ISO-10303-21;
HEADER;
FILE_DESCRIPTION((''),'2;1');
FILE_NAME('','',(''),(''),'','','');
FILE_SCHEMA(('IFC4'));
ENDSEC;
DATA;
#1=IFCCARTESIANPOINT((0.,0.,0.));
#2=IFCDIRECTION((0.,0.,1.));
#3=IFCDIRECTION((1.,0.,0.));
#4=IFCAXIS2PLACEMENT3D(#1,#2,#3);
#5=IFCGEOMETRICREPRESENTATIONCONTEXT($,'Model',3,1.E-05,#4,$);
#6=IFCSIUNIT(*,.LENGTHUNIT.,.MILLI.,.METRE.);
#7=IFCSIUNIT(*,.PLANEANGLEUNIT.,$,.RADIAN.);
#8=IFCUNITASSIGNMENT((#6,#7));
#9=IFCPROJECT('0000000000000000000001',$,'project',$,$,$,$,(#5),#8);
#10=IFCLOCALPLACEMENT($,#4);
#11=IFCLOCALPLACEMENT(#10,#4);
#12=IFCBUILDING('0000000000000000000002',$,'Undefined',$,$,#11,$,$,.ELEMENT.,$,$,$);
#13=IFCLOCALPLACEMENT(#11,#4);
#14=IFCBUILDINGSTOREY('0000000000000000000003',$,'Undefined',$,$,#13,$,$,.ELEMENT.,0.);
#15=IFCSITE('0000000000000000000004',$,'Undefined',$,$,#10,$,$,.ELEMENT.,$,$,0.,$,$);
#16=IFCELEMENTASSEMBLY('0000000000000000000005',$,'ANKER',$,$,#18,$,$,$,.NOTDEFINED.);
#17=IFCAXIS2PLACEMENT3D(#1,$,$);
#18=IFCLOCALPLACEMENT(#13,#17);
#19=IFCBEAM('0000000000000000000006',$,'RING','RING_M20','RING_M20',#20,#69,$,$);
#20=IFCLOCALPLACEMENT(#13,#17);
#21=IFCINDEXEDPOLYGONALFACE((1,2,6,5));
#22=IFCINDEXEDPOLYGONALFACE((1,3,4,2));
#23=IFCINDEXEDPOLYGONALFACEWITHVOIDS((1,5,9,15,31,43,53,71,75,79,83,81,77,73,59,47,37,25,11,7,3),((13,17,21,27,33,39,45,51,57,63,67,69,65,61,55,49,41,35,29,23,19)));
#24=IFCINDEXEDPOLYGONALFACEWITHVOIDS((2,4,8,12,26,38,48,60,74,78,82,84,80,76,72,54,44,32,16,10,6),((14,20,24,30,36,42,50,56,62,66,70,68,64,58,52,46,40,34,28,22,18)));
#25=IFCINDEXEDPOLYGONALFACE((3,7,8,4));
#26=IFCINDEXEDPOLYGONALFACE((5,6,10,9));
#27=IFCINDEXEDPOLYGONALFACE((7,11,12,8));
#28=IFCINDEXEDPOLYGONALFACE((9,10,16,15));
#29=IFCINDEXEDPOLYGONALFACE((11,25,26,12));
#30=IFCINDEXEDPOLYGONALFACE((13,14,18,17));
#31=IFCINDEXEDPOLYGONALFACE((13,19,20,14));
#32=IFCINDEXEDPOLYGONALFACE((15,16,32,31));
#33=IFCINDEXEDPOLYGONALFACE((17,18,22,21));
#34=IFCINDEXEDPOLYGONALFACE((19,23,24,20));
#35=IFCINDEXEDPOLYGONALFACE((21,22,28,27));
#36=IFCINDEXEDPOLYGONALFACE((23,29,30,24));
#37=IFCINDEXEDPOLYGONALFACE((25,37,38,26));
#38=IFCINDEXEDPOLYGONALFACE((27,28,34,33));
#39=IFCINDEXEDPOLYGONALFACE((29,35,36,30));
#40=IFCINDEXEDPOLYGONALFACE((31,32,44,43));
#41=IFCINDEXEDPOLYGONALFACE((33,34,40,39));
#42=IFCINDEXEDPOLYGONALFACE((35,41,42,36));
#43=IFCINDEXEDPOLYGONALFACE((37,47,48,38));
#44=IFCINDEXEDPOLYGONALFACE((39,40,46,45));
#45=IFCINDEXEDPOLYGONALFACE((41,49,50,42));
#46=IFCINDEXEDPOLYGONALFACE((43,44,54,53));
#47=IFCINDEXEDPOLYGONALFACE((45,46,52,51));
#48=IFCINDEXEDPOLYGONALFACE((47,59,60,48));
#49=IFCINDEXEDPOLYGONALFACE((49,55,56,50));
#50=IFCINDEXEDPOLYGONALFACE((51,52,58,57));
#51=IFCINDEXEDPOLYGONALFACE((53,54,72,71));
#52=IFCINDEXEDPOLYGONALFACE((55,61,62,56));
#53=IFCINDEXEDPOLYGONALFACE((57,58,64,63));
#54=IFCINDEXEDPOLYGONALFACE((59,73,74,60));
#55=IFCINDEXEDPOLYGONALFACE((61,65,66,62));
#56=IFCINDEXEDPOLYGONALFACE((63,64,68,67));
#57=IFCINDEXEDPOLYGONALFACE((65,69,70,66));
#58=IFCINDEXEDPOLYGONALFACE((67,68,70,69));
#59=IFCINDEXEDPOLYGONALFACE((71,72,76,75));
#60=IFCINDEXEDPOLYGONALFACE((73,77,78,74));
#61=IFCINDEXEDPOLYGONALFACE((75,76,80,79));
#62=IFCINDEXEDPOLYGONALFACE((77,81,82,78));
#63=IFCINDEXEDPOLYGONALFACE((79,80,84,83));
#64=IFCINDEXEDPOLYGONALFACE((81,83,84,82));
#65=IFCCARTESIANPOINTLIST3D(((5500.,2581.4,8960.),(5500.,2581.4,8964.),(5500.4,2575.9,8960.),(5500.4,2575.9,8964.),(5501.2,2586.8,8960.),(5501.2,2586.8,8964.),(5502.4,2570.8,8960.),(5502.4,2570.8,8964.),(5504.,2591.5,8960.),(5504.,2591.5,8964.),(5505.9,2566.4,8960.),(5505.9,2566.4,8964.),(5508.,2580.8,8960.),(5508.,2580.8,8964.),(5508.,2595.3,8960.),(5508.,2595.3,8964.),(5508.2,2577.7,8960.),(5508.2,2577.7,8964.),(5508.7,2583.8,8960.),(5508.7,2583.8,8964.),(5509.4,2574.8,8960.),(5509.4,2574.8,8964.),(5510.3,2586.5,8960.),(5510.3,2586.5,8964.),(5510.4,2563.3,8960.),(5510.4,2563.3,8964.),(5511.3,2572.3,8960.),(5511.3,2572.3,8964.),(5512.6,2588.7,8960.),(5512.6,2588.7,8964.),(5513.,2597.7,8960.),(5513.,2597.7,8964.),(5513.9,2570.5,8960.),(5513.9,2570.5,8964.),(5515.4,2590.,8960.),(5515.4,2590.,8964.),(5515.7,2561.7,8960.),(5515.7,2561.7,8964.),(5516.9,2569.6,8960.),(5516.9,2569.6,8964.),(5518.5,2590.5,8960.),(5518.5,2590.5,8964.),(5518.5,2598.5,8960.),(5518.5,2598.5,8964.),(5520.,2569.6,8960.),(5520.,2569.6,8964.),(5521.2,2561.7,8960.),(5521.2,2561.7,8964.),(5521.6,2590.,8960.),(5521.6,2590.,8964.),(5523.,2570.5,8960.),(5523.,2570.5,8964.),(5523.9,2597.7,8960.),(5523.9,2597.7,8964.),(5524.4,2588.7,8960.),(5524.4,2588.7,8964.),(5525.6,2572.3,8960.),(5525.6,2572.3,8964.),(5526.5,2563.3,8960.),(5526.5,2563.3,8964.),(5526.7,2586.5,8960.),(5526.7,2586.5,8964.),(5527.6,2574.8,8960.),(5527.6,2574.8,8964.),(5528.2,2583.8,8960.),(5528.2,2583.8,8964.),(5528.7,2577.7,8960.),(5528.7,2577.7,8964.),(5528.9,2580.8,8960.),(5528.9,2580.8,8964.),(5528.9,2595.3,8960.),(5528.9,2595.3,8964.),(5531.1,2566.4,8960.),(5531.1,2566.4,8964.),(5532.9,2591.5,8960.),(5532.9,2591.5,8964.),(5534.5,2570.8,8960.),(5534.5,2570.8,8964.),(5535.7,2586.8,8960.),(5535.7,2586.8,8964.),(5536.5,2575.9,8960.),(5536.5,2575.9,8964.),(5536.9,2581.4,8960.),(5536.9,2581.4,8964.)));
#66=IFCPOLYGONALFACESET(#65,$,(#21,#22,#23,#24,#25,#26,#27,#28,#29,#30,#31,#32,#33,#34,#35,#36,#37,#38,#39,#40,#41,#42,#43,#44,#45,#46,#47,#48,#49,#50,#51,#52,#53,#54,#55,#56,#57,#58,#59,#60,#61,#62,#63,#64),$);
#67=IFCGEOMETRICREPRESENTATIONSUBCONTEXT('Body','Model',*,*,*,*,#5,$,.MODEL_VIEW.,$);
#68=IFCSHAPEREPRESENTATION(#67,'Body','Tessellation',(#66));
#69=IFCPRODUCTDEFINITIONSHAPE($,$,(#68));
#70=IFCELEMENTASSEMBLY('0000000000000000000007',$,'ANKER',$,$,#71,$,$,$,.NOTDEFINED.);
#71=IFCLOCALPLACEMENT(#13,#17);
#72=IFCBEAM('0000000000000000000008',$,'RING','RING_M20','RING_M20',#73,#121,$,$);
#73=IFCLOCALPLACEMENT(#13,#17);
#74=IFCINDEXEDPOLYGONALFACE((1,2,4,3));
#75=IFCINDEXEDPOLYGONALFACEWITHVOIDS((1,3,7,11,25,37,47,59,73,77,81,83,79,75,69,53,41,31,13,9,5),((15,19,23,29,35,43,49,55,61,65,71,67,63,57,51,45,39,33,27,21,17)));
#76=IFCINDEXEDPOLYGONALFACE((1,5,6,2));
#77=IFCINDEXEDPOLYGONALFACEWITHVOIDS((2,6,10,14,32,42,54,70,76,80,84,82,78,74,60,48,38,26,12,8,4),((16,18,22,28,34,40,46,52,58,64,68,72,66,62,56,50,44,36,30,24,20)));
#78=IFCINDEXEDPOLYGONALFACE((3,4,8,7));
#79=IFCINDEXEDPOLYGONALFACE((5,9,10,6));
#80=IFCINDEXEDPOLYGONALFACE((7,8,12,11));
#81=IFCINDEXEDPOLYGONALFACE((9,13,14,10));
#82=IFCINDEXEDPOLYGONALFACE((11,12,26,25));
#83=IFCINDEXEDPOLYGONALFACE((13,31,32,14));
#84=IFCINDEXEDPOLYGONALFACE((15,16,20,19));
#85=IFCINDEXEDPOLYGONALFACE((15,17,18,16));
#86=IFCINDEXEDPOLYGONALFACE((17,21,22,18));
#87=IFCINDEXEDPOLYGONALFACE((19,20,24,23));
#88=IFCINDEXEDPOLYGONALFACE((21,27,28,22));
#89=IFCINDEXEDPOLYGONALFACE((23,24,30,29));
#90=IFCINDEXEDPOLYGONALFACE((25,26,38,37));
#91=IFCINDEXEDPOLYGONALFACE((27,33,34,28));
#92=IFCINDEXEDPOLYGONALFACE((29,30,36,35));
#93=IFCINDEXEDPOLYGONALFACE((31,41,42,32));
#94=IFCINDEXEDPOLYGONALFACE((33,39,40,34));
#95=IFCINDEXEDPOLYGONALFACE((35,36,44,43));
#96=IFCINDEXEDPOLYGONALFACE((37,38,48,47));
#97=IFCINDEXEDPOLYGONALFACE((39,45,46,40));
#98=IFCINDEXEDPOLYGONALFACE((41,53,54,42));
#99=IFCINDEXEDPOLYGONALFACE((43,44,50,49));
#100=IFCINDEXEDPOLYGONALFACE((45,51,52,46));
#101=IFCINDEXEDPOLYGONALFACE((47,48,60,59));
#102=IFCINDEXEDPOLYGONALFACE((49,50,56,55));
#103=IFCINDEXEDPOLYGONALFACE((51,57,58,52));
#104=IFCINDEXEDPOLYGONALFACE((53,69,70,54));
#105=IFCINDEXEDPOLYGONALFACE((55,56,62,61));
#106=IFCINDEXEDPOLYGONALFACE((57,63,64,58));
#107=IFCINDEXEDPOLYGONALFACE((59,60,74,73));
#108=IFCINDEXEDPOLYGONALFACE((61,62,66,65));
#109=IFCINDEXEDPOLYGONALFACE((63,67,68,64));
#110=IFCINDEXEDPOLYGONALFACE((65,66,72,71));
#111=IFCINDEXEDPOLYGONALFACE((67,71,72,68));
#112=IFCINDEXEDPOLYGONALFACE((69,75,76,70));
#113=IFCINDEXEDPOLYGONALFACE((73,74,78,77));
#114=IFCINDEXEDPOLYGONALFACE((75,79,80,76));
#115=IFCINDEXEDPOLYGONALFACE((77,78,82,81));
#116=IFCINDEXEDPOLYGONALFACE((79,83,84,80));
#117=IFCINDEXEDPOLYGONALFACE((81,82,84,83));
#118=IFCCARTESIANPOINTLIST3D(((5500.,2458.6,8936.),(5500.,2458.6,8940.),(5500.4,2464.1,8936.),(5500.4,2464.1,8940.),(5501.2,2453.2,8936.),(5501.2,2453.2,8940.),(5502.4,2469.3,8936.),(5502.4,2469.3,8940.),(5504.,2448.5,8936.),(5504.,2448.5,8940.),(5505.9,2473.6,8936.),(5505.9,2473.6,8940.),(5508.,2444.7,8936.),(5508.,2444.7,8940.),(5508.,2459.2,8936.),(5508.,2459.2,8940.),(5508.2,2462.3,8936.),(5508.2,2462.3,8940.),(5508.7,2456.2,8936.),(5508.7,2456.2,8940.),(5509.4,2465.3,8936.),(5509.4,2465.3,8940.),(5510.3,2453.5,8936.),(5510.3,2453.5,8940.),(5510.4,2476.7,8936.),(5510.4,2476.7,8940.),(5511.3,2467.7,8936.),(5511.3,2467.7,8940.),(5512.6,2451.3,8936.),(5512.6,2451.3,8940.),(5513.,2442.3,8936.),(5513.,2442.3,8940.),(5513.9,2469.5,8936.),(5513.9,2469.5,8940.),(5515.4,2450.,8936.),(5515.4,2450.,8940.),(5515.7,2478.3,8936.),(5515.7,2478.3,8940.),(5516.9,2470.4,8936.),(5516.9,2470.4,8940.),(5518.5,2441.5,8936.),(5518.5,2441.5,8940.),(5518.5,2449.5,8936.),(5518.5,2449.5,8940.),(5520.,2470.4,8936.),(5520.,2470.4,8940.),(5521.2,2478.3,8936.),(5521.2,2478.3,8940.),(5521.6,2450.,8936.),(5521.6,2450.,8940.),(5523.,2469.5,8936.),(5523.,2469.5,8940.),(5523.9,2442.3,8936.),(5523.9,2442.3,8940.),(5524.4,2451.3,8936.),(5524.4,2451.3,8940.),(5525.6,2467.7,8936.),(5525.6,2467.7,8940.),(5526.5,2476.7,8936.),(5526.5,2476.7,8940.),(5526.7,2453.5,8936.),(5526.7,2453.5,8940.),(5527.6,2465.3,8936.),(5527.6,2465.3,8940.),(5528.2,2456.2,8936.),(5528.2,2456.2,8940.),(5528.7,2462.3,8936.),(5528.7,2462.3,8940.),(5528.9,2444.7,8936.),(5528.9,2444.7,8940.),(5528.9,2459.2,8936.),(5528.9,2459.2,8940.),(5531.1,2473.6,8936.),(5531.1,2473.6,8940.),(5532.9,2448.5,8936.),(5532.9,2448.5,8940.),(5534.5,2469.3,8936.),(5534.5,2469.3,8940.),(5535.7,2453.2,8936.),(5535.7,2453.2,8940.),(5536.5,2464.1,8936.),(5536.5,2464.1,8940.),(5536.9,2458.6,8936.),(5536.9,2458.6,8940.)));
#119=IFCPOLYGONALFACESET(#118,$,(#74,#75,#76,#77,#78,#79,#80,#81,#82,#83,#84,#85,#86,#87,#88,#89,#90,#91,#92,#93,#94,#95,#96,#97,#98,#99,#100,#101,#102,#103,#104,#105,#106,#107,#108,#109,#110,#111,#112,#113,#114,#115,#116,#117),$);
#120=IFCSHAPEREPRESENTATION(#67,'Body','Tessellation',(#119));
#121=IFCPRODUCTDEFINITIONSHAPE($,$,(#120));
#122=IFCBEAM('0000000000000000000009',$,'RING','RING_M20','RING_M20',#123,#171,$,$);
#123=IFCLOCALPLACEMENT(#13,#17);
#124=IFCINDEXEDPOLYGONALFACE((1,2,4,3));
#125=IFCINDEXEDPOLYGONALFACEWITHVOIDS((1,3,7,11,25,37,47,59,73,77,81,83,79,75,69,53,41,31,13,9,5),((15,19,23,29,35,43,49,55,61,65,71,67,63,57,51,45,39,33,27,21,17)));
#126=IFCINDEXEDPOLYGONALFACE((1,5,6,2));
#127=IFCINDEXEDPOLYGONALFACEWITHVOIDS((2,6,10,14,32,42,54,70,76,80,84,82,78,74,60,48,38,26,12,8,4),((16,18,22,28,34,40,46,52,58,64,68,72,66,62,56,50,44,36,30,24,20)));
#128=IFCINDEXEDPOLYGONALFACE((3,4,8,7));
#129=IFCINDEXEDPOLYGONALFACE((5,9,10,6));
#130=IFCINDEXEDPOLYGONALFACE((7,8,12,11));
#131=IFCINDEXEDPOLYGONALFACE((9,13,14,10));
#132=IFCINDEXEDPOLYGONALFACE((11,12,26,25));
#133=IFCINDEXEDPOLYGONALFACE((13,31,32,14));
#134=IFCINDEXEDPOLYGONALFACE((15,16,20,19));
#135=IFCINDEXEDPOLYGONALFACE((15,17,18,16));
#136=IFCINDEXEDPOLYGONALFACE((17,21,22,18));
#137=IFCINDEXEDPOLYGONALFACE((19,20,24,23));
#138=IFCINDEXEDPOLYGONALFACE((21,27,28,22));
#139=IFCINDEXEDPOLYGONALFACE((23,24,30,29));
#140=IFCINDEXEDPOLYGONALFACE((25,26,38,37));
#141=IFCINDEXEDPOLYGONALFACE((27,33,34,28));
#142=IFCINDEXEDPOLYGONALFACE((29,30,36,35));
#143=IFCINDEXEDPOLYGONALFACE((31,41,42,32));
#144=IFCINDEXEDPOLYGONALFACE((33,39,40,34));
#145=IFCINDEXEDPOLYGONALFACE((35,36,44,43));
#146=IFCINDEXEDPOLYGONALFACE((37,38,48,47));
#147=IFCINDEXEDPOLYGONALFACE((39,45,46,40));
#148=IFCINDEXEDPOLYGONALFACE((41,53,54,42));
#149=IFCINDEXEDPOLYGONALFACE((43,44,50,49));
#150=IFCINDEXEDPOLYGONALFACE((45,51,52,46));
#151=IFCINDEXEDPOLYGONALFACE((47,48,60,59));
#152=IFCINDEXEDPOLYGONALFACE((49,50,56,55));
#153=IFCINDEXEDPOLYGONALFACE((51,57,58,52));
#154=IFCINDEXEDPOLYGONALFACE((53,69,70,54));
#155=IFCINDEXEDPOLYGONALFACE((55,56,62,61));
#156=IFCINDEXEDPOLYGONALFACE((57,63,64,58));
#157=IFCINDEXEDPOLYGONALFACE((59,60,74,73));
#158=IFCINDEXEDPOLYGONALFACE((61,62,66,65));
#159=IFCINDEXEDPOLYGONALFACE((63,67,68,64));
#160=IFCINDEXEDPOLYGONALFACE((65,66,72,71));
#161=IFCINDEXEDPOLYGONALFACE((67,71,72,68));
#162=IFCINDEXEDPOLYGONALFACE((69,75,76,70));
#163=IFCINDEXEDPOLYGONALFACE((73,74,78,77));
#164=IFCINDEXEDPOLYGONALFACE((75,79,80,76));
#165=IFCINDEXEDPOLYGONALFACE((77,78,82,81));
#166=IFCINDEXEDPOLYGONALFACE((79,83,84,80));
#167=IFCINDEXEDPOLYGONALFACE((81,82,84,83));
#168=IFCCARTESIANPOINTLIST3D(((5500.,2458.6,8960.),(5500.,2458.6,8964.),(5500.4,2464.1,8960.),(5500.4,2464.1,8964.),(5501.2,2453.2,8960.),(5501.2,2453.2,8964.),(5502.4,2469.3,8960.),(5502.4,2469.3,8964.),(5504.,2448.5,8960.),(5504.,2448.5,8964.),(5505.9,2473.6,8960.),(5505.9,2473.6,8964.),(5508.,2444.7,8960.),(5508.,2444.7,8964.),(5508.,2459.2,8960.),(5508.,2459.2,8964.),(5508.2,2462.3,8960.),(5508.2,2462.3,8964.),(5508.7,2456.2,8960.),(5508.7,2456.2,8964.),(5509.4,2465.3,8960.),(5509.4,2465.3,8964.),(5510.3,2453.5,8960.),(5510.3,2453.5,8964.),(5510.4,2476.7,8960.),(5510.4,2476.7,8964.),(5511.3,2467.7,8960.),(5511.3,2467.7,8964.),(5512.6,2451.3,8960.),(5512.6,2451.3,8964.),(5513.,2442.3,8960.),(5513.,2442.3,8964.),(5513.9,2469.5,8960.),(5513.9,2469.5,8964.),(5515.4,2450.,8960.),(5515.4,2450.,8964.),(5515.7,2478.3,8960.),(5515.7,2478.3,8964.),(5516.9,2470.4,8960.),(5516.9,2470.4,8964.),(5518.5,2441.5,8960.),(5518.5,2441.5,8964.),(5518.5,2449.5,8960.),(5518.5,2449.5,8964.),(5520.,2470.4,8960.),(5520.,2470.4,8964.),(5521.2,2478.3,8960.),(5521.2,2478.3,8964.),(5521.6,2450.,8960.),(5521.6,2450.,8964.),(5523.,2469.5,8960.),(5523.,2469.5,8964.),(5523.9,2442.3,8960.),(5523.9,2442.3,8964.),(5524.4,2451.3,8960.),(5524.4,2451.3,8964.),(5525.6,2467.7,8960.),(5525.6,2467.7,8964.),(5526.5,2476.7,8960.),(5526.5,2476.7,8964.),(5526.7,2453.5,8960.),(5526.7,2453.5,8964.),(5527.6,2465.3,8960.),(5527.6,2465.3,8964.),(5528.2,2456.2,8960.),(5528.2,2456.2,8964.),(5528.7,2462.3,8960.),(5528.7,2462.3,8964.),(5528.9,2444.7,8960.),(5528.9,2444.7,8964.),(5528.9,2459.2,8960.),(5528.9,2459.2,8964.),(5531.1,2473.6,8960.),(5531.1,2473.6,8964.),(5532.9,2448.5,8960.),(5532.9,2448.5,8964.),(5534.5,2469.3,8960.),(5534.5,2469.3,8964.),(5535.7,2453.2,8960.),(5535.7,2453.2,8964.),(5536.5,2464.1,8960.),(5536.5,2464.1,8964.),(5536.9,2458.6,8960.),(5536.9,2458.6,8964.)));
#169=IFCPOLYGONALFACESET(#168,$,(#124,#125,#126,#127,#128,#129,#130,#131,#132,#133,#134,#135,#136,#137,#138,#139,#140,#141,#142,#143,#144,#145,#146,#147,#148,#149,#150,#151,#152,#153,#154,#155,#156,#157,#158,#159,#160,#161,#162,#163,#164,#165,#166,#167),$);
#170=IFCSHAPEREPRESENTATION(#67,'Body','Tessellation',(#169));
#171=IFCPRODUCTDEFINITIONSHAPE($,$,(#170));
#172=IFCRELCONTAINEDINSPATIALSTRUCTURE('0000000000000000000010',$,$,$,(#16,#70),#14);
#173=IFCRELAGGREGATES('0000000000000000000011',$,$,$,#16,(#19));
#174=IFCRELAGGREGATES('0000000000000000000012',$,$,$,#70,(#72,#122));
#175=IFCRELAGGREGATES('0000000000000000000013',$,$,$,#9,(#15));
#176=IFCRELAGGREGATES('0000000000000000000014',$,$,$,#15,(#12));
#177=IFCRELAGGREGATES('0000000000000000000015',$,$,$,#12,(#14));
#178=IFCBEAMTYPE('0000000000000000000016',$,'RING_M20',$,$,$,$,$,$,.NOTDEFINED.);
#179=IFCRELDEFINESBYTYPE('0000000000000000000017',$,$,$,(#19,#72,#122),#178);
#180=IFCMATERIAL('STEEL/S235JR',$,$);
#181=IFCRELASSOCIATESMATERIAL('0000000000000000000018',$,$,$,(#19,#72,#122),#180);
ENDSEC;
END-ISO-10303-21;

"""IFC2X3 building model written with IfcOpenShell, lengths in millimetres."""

from ifc_helpers import new_model, si_unit, frame, origin_with_axes, origin_2d_with_axis, place, context, subcontext, project, spatial, hollow_circle, extrude, material, type_object, element, aggregate, save


model = new_model("IFC2X3")

# Units and contexts
model_context = context("Model", 3, precision=1e-05, world=origin_with_axes())
body_context = subcontext(model_context, "Body", "Model", "MODEL_VIEW")
ifc_project = project(units=[si_unit("LENGTHUNIT", "METRE", prefix="MILLI"), si_unit("PLANEANGLEUNIT", "RADIAN")], contexts=[model_context])

# Site, building, storey
site_placement = place(None, origin_with_axes())
site = spatial("IfcSite", under=ifc_project, at=site_placement, Name="Undefined", CompositionType="ELEMENT", RefElevation=0.0)
building_placement = place(site_placement, origin_with_axes())
building = spatial("IfcBuilding", under=site, at=building_placement, Name="Undefined", CompositionType="ELEMENT")
storey_placement = place(building_placement, origin_with_axes())
storey = spatial("IfcBuildingStorey", under=building, at=storey_placement, Name="Undefined", CompositionType="ELEMENT", Elevation=0.0)

# Shared definitions
ifc_material = material(Name="STEEL/S235JR")

# Shared definitions
beam_type_1 = type_object("IfcBeamType", Name="RING_M20", PredefinedType="NOTDEFINED")

# Element assemblies, beams
assembly_1_placement = place(storey_placement, frame((5518.5, 2580.0, 9010.0), z_axis=(0.0, 1.0, 0.0), x_axis=(0.0, 0.0, -1.0)))
assembly_1 = element("IfcElementAssembly", 1, at=assembly_1_placement, inside=storey, Name="ANKER", PredefinedType="NOTDEFINED")
beam_1_placement = place(storey_placement, frame((5518.5, 2580.0, 8964.0), z_axis=(-1.0, 0.0, 0.0), x_axis=(0.0, 0.0, -1.0)))
beam_1 = element("IfcBeam", 2, at=beam_1_placement, type_object=beam_type_1, material=ifc_material, Name="RING", Description="RING_M20", ObjectType="RING_M20", context=body_context, shape_type="SweptSolid", body=[
    extrude(hollow_circle(Radius=18.5, WallThickness=8.0, at=origin_2d_with_axis()), frame((4.0, 0.0, 0.0), z_axis=(-1.0, 0.0, 0.0), x_axis=(0.0, -1.0, 0.0)), (0.0, 0.0, 1.0), 4.0),
])
aggregate(assembly_1, [beam_1])
assembly_2_placement = place(storey_placement, frame((5518.5, 2460.0, 9010.0), z_axis=(0.0, 1.0, 0.0), x_axis=(0.0, 0.0, -1.0)))
assembly_2 = element("IfcElementAssembly", 3, at=assembly_2_placement, inside=storey, Name="ANKER", PredefinedType="NOTDEFINED")
beam_2_placement = place(storey_placement, frame((5518.5, 2460.0, 8940.0), z_axis=(1.0, 0.0, 0.0), x_axis=(0.0, 0.0, -1.0)))
beam_2 = element("IfcBeam", 4, at=beam_2_placement, type_object=beam_type_1, material=ifc_material, Name="RING", Description="RING_M20", ObjectType="RING_M20", context=body_context, shape_type="SweptSolid", body=[
    extrude(hollow_circle(Radius=18.5, WallThickness=8.0, at=origin_2d_with_axis()), frame((4.0, 0.0, 0.0), z_axis=(-1.0, 0.0, 0.0), x_axis=(0.0, -1.0, 0.0)), (0.0, 0.0, 1.0), 4.0),
])
beam_3_placement = place(storey_placement, frame((5518.5, 2460.0, 8964.0), z_axis=(1.0, 0.0, 0.0), x_axis=(0.0, 0.0, -1.0)))
beam_3 = element("IfcBeam", 5, at=beam_3_placement, type_object=beam_type_1, material=ifc_material, Name="RING", Description="RING_M20", ObjectType="RING_M20", context=body_context, shape_type="SweptSolid", body=[
    extrude(hollow_circle(Radius=18.5, WallThickness=8.0, at=origin_2d_with_axis()), frame((4.0, 0.0, 0.0), z_axis=(-1.0, 0.0, 0.0), x_axis=(0.0, -1.0, 0.0)), (0.0, 0.0, 1.0), 4.0),
])
aggregate(assembly_2, [beam_2, beam_3])

save(model, "model.ifc")
